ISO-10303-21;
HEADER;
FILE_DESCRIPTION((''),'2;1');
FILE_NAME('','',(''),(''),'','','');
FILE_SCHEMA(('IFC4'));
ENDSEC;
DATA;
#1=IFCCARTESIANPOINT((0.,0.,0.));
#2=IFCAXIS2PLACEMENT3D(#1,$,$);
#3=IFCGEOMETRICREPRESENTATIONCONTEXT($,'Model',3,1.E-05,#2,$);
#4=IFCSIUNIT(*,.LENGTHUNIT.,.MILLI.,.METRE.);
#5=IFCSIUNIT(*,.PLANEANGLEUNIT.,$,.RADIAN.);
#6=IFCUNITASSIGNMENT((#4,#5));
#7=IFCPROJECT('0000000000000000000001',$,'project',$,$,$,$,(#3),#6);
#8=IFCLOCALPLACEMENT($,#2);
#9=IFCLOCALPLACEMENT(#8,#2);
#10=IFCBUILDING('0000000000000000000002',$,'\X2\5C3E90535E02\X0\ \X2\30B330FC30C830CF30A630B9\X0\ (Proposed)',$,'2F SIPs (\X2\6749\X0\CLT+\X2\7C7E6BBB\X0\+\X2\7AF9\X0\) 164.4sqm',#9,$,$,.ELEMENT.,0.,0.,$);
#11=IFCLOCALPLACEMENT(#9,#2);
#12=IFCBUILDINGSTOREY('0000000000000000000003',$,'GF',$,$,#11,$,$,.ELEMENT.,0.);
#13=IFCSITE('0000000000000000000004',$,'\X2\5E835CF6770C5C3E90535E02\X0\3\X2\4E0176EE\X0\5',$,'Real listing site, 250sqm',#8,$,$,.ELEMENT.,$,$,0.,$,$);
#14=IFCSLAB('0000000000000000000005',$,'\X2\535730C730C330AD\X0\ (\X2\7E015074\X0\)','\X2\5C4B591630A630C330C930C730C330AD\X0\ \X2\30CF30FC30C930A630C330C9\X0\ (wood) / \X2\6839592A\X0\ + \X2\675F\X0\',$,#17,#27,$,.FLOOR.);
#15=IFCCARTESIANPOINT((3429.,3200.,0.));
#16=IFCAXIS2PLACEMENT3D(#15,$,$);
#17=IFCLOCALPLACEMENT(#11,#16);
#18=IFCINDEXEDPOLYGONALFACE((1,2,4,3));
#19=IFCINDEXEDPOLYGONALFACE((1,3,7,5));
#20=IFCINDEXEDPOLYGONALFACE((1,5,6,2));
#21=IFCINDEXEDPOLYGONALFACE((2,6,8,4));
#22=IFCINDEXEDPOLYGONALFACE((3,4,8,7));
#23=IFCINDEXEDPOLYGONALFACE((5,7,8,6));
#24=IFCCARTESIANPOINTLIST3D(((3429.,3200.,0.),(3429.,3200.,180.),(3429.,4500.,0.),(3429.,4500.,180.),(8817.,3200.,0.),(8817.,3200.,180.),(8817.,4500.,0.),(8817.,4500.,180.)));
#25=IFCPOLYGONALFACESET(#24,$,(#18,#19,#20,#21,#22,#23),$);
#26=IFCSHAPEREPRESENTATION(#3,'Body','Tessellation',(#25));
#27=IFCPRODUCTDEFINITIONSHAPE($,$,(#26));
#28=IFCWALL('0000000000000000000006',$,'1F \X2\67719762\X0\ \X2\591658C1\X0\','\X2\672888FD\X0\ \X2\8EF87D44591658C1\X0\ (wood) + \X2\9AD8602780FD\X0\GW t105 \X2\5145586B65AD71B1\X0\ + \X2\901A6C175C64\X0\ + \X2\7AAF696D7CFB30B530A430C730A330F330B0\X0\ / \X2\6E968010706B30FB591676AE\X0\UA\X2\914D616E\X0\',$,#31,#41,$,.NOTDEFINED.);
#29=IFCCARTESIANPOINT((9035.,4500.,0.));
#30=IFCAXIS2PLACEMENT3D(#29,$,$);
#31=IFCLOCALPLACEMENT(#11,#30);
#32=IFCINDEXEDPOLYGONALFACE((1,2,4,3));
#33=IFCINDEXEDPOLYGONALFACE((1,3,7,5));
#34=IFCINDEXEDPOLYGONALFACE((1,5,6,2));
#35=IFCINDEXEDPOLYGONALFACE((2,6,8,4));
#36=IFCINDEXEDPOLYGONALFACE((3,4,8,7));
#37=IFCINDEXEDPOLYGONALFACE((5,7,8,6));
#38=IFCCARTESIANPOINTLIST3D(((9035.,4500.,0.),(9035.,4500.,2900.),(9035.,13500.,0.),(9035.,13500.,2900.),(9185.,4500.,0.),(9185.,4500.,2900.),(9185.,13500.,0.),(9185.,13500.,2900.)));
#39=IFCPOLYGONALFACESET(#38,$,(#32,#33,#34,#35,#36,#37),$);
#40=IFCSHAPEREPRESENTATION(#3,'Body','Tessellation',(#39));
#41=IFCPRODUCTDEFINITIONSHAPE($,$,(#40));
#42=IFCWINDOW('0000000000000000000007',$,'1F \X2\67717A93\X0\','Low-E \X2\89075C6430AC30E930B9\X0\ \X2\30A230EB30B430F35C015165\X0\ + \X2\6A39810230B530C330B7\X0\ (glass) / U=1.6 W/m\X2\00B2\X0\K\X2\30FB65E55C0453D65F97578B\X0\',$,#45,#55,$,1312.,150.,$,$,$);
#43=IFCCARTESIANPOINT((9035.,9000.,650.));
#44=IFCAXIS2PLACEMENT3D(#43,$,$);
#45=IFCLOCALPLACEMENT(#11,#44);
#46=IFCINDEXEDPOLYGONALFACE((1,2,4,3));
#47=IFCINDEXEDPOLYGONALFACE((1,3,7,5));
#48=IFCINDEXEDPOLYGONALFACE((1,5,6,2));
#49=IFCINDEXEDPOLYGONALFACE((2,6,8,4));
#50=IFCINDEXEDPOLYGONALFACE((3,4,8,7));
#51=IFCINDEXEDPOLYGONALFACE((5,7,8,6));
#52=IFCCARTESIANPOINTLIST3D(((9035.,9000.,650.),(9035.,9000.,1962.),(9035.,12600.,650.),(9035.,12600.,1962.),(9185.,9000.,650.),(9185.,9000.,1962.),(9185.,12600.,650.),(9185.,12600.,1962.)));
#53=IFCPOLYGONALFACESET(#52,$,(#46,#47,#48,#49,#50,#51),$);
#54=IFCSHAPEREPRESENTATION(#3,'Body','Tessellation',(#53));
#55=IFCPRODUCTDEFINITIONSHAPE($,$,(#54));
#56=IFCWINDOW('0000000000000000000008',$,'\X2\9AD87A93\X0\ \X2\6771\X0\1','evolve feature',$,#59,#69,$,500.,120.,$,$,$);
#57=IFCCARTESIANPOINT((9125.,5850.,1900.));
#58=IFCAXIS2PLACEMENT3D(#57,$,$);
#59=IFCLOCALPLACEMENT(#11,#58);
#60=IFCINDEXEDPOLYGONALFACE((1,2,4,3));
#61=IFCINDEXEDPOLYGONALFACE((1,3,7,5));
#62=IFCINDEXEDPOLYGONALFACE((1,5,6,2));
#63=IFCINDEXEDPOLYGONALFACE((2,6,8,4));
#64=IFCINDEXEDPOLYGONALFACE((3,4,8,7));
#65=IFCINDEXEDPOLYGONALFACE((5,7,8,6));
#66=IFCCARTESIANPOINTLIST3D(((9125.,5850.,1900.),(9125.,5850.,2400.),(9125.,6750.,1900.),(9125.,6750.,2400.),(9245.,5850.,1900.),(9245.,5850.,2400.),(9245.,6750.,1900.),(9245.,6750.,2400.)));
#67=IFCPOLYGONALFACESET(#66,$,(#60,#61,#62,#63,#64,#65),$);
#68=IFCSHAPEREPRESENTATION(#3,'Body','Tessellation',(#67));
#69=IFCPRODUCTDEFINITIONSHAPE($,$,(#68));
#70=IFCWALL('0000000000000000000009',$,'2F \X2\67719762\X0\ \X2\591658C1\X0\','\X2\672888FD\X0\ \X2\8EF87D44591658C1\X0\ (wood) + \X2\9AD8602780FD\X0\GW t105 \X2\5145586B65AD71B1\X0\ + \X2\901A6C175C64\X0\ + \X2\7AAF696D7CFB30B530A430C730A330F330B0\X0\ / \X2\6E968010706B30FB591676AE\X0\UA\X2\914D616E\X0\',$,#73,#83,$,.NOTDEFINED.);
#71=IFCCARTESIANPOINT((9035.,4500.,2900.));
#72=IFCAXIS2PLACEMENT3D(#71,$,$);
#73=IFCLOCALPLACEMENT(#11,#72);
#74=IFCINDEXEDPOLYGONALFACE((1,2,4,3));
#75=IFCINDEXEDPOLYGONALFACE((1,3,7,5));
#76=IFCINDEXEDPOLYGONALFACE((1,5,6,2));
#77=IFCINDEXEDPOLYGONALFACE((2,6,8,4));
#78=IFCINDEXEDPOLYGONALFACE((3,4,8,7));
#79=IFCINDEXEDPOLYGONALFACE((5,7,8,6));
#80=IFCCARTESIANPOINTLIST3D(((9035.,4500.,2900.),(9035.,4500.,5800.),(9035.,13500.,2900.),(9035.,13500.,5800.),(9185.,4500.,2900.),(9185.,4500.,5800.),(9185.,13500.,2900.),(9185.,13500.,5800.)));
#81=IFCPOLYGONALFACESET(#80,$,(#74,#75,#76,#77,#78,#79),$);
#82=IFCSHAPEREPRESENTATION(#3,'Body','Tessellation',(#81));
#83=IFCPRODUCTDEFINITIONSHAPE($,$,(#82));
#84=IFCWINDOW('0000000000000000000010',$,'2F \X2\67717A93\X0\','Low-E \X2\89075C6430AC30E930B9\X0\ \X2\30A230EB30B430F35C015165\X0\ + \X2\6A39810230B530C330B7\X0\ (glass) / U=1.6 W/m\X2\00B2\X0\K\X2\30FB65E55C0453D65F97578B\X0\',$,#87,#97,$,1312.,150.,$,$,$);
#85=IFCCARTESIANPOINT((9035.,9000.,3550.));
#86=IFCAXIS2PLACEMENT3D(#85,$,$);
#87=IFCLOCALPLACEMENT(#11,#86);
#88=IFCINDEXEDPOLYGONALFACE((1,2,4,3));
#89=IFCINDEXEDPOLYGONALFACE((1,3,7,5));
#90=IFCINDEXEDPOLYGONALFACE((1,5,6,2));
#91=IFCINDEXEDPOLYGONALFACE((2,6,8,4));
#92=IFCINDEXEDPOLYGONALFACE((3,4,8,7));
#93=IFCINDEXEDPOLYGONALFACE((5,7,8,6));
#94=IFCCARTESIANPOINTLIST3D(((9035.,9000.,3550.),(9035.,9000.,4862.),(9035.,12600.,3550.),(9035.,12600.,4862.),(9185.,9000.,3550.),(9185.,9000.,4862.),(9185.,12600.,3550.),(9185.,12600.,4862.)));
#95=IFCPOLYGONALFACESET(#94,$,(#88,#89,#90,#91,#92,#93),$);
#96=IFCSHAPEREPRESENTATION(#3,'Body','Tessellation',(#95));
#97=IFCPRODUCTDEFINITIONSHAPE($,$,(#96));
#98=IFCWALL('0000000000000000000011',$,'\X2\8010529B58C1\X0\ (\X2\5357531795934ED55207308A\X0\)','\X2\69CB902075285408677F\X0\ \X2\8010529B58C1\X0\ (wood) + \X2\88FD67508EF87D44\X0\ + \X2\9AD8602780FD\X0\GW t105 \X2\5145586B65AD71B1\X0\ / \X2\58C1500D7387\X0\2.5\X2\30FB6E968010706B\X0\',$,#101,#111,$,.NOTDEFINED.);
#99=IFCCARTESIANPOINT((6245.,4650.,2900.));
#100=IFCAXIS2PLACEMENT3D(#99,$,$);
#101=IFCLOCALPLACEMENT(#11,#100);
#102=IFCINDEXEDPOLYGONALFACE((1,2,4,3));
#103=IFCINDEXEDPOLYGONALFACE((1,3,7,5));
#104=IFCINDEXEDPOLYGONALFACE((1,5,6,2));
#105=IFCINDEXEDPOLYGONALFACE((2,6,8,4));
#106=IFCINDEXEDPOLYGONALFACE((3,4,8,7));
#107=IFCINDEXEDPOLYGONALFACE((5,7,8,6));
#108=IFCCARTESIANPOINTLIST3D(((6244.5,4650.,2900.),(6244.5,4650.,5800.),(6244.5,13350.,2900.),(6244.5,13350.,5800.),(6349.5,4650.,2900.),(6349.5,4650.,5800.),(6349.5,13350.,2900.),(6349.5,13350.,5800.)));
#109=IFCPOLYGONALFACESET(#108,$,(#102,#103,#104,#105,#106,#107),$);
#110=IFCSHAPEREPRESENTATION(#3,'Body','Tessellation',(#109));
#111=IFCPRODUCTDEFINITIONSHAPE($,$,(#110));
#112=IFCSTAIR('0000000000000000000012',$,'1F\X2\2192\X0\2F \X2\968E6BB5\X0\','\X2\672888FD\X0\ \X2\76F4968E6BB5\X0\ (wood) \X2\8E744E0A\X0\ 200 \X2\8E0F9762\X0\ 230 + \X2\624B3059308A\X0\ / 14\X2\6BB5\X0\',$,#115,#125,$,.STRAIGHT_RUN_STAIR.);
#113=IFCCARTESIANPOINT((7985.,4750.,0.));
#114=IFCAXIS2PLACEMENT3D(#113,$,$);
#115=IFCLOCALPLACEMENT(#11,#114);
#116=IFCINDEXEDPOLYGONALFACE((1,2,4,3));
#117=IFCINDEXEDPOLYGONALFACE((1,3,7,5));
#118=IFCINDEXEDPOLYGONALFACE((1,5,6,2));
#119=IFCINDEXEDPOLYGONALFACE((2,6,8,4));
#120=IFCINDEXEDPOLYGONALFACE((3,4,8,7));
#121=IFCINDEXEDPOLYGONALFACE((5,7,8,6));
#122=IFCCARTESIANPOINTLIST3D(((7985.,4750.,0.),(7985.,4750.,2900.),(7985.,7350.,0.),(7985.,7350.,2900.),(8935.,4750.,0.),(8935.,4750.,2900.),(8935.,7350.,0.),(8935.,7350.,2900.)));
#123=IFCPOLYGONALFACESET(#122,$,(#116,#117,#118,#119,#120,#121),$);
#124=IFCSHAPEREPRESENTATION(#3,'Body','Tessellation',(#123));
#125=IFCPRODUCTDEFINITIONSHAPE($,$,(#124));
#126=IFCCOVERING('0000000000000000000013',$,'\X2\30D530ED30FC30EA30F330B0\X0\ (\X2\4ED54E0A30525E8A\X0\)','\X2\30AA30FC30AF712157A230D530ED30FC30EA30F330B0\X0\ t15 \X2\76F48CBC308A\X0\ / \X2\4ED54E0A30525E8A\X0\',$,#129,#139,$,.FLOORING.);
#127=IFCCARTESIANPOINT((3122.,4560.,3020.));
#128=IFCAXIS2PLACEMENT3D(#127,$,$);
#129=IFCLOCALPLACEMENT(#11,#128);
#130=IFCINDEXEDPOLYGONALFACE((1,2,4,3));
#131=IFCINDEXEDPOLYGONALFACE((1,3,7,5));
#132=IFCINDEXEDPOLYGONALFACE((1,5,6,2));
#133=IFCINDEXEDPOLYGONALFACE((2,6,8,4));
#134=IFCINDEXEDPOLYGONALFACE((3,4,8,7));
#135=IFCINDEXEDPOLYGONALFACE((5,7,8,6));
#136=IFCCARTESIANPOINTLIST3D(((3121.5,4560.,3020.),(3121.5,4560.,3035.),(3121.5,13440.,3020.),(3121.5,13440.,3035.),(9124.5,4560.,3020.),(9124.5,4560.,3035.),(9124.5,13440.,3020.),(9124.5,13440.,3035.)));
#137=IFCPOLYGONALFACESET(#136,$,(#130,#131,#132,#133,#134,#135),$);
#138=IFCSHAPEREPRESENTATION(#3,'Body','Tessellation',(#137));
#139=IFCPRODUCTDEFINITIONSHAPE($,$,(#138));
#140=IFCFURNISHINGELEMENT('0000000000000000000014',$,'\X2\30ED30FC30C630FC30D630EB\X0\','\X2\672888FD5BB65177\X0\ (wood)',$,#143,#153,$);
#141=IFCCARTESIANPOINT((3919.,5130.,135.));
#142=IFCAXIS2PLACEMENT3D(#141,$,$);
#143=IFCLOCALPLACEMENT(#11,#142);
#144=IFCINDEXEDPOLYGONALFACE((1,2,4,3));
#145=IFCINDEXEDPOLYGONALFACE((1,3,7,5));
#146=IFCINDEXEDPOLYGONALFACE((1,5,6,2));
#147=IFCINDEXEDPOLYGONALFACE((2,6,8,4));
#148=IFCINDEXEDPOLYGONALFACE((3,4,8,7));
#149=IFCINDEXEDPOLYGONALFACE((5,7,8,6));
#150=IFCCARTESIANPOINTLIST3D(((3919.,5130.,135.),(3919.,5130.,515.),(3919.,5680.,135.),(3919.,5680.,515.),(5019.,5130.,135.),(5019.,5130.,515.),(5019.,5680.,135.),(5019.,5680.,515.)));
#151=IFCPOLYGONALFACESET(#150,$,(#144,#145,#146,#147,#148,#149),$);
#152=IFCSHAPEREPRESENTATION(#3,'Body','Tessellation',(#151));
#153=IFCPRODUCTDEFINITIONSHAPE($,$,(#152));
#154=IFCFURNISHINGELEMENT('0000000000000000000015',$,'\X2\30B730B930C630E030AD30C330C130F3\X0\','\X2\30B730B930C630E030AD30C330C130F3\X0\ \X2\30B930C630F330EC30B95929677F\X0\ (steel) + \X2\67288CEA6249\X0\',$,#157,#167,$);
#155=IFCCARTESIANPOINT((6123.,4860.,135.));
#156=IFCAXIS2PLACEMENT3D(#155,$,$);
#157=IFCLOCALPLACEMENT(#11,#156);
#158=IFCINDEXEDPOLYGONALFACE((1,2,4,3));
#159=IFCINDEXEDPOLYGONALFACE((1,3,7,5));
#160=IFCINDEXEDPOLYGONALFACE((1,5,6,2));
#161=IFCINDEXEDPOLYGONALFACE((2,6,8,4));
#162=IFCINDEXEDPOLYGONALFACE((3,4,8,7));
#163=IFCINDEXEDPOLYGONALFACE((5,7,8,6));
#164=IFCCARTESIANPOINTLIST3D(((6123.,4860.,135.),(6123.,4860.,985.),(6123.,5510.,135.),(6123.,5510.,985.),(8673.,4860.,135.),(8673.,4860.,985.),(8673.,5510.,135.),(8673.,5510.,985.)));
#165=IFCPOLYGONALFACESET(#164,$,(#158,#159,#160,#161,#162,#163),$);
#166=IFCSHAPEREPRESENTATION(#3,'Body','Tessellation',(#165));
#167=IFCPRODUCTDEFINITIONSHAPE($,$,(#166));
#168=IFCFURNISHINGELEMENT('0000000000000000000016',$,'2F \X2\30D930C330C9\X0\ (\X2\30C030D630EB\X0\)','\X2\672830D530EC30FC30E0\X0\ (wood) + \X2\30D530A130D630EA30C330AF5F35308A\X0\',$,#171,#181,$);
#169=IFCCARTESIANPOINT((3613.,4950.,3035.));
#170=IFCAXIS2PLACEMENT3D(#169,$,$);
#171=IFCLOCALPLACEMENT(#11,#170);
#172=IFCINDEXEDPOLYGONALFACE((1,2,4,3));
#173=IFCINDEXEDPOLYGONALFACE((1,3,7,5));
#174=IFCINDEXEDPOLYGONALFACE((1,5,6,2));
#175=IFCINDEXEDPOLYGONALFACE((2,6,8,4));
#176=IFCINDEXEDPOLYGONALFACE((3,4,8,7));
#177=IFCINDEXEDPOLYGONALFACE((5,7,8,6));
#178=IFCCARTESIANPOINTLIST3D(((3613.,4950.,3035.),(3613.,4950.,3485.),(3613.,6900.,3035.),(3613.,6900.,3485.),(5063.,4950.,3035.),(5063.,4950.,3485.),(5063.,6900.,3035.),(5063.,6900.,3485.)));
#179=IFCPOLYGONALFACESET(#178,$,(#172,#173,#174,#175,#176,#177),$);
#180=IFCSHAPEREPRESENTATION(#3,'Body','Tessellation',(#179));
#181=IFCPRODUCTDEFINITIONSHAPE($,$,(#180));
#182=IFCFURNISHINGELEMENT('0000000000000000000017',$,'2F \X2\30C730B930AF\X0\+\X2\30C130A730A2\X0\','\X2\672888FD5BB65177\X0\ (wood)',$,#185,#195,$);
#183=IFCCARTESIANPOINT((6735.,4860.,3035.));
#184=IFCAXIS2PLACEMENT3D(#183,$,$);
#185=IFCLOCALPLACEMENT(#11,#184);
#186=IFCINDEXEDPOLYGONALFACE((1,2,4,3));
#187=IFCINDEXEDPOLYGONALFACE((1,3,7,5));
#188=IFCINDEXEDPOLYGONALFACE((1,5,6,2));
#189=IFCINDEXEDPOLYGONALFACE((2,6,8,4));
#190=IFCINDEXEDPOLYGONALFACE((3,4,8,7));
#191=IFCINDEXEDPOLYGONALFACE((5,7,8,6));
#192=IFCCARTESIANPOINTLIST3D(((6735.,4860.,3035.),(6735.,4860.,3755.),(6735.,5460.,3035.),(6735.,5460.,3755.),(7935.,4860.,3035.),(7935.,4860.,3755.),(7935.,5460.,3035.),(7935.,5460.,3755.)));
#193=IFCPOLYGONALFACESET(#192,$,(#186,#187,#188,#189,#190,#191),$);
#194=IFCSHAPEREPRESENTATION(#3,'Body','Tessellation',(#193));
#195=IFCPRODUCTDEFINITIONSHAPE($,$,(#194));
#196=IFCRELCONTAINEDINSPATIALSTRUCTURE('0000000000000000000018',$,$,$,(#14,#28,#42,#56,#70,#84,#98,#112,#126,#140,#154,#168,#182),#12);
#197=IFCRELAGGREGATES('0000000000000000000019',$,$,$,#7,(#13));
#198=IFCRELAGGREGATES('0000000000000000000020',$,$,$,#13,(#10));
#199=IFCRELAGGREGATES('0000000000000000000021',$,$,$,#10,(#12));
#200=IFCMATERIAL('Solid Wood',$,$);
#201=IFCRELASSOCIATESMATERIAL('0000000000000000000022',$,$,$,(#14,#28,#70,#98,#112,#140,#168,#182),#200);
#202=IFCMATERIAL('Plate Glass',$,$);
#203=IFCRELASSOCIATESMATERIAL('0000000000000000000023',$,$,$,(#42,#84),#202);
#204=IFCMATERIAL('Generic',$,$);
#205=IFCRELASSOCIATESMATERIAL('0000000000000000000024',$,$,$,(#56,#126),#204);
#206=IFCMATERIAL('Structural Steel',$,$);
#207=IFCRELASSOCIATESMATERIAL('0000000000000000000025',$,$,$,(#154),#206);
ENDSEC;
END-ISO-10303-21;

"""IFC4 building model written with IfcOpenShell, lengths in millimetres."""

from ifc_helpers import new_model, si_unit, frame, frame_2d, origin, place, context, project, spatial, rectangle, extrude, material, element, fill, save


model = new_model("IFC4")

# Units and contexts
model_context = context("Model", 3, precision=1e-05, world=origin())
ifc_project = project(units=[si_unit("LENGTHUNIT", "METRE", prefix="MILLI"), si_unit("PLANEANGLEUNIT", "RADIAN")], contexts=[model_context])

# Site, building, storey
site_placement = place(None, origin())
site = spatial("IfcSite", under=ifc_project, at=site_placement, Name="広島県尾道市3丁目5", ObjectType="Real listing site, 250sqm", CompositionType="ELEMENT", RefElevation=0.0)
building_placement = place(site_placement, origin())
building = spatial("IfcBuilding", under=site, at=building_placement, Name="尾道市 コートハウス (Proposed)", ObjectType="2F SIPs (杉CLT+籾殻+竹) 164.4sqm", CompositionType="ELEMENT", ElevationOfRefHeight=0.0, ElevationOfTerrain=0.0)
storey_placement = place(building_placement, origin())
storey = spatial("IfcBuildingStorey", under=building, at=storey_placement, Name="GF", CompositionType="ELEMENT", Elevation=0.0)

# Slab
ifc_material_1 = material(Name="Solid Wood")
slab_placement = place(storey_placement, frame((3429.0, 3200.0, 0.0)))
element("IfcSlab", 1, at=slab_placement, inside=storey, material=ifc_material_1, Name="南デッキ (縁側)", Description="屋外ウッドデッキ ハードウッド (wood) / 根太 + 束", PredefinedType="FLOOR", context=model_context, shape_type="SweptSolid", body=[
    extrude(rectangle(XDim=5388.0, YDim=1300.0, at=frame_2d((2694.0, 650.0))), frame((3429.0, 3200.0, 0.0)), (0.0, 0.0, 1.0), 180.0),
])

# Wall, openings, windows
wall_1_placement = place(storey_placement, frame((9035.0, 4500.0, 0.0)))
wall_1 = element("IfcWall", 2, at=wall_1_placement, inside=storey, material=ifc_material_1, Name="1F 東面 外壁", Description="木製 軸組外壁 (wood) + 高性能GW t105 充填断熱 + 通気層 + 窯業系サイディング / 準耐火・外皮UA配慮", PredefinedType="NOTDEFINED", context=model_context, shape_type="SweptSolid", body=[
    extrude(rectangle(XDim=150.0, YDim=9000.0, at=frame_2d((75.0, 4500.0))), frame((9035.0, 4500.0, 0.0)), (0.0, 0.0, 1.0), 2900.0),
])
opening_1_placement = place(storey_placement, frame((9035.0, 9000.0, 650.0)))
opening_1 = element("IfcOpeningElement", 3, at=opening_1_placement, cuts=wall_1, PredefinedType="NOTDEFINED", context=model_context, shape_type="SweptSolid", body=[
    extrude(rectangle(XDim=150.0, YDim=3600.0, at=frame_2d((75.0, 1800.0))), frame((9035.0, 9000.0, 650.0)), (0.0, 0.0, 1.0), 1312.0),
])
opening_2_placement = place(storey_placement, frame((9125.0, 5850.0, 1900.0)))
opening_2 = element("IfcOpeningElement", 4, at=opening_2_placement, cuts=wall_1, PredefinedType="NOTDEFINED", context=model_context, shape_type="SweptSolid", body=[
    extrude(rectangle(XDim=120.0, YDim=900.0, at=frame_2d((60.0, 450.0))), frame((9125.0, 5850.0, 1900.0)), (0.0, 0.0, 1.0), 500.0),
])
ifc_material_2 = material(Name="Plate Glass")
window_1_placement = place(storey_placement, frame((9035.0, 9000.0, 650.0)))
window_1 = element("IfcWindow", 5, at=window_1_placement, inside=storey, material=ifc_material_2, Name="1F 東窓", Description="Low-E 複層ガラス アルゴン封入 + 樹脂サッシ (glass) / U=1.6 W/m²K・日射取得型", OverallHeight=1312.0, OverallWidth=150.0, context=model_context, shape_type="SweptSolid", body=[
    extrude(rectangle(XDim=150.0, YDim=3600.0, at=frame_2d((75.0, 1800.0))), frame((9035.0, 9000.0, 650.0)), (0.0, 0.0, 1.0), 1312.0),
])
fill(opening_1, window_1)
ifc_material_3 = material(Name="Generic")
window_2_placement = place(storey_placement, frame((9125.0, 5850.0, 1900.0)))
window_2 = element("IfcWindow", 6, at=window_2_placement, inside=storey, material=ifc_material_3, Name="高窓 東1", Description="evolve feature", OverallHeight=500.0, OverallWidth=120.0, context=model_context, shape_type="SweptSolid", body=[
    extrude(rectangle(XDim=120.0, YDim=900.0, at=frame_2d((60.0, 450.0))), frame((9125.0, 5850.0, 1900.0)), (0.0, 0.0, 1.0), 500.0),
])
fill(opening_2, window_2)

# Wall, opening, window
wall_2_placement = place(storey_placement, frame((9035.0, 4500.0, 2900.0)))
wall_2 = element("IfcWall", 7, at=wall_2_placement, inside=storey, material=ifc_material_1, Name="2F 東面 外壁", Description="木製 軸組外壁 (wood) + 高性能GW t105 充填断熱 + 通気層 + 窯業系サイディング / 準耐火・外皮UA配慮", PredefinedType="NOTDEFINED", context=model_context, shape_type="SweptSolid", body=[
    extrude(rectangle(XDim=150.0, YDim=9000.0, at=frame_2d((75.0, 4500.0))), frame((9035.0, 4500.0, 2900.0)), (0.0, 0.0, 1.0), 2900.0),
])
opening_3_placement = place(storey_placement, frame((9035.0, 9000.0, 3550.0)))
opening_3 = element("IfcOpeningElement", 8, at=opening_3_placement, cuts=wall_2, PredefinedType="NOTDEFINED", context=model_context, shape_type="SweptSolid", body=[
    extrude(rectangle(XDim=150.0, YDim=3600.0, at=frame_2d((75.0, 1800.0))), frame((9035.0, 9000.0, 3550.0)), (0.0, 0.0, 1.0), 1312.0),
])
window_3_placement = place(storey_placement, frame((9035.0, 9000.0, 3550.0)))
window_3 = element("IfcWindow", 9, at=window_3_placement, inside=storey, material=ifc_material_2, Name="2F 東窓", Description="Low-E 複層ガラス アルゴン封入 + 樹脂サッシ (glass) / U=1.6 W/m²K・日射取得型", OverallHeight=1312.0, OverallWidth=150.0, context=model_context, shape_type="SweptSolid", body=[
    extrude(rectangle(XDim=150.0, YDim=3600.0, at=frame_2d((75.0, 1800.0))), frame((9035.0, 9000.0, 3550.0)), (0.0, 0.0, 1.0), 1312.0),
])
fill(opening_3, window_3)

# Wall
wall_3_placement = place(storey_placement, frame((6245.0, 4650.0, 2900.0)))
element("IfcWall", 10, at=wall_3_placement, inside=storey, material=ifc_material_1, Name="耐力壁 (南北間仕切り)", Description="構造用合板 耐力壁 (wood) + 製材軸組 + 高性能GW t105 充填断熱 / 壁倍率2.5・準耐火", PredefinedType="NOTDEFINED", context=model_context, shape_type="SweptSolid", body=[
    extrude(rectangle(XDim=105.0, YDim=8700.0, at=frame_2d((52.0, 4350.0))), frame((6245.0, 4650.0, 2900.0)), (0.0, 0.0, 1.0), 2900.0),
])

# Stair
stair_placement = place(storey_placement, frame((7985.0, 4750.0, 0.0)))
element("IfcStair", 11, at=stair_placement, inside=storey, material=ifc_material_1, Name="1F→2F 階段", Description="木製 直階段 (wood) 蹴上 200 踏面 230 + 手すり / 14段", PredefinedType="STRAIGHT_RUN_STAIR", context=model_context, shape_type="SweptSolid", body=[
    extrude(rectangle(XDim=950.0, YDim=2600.0, at=frame_2d((475.0, 1300.0))), frame((7985.0, 4750.0, 0.0)), (0.0, 0.0, 1.0), 2900.0),
])

# Covering
covering_placement = place(storey_placement, frame((3122.0, 4560.0, 3020.0)))
element("IfcCovering", 12, at=covering_placement, inside=storey, material=ifc_material_3, Name="フローリング (仕上げ床)", Description="オーク無垢フローリング t15 直貼り / 仕上げ床", PredefinedType="FLOORING", context=model_context, shape_type="SweptSolid", body=[
    extrude(rectangle(XDim=6003.0, YDim=8880.0, at=frame_2d((3001.0, 4440.0))), frame((3122.0, 4560.0, 3020.0)), (0.0, 0.0, 1.0), 15.0),
])

# Furnishing elements
furnishing_1_placement = place(storey_placement, frame((3919.0, 5130.0, 135.0)))
element("IfcFurnishingElement", 13, at=furnishing_1_placement, inside=storey, material=ifc_material_1, Name="ローテーブル", Description="木製家具 (wood)", context=model_context, shape_type="SweptSolid", body=[
    extrude(rectangle(XDim=1100.0, YDim=550.0, at=frame_2d((550.0, 275.0))), frame((3919.0, 5130.0, 135.0)), (0.0, 0.0, 1.0), 380.0),
])
ifc_material_4 = material(Name="Structural Steel")
furnishing_2_placement = place(storey_placement, frame((6123.0, 4860.0, 135.0)))
element("IfcFurnishingElement", 14, at=furnishing_2_placement, inside=storey, material=ifc_material_4, Name="システムキッチン", Description="システムキッチン ステンレス天板 (steel) + 木質扉", context=model_context, shape_type="SweptSolid", body=[
    extrude(rectangle(XDim=2550.0, YDim=650.0, at=frame_2d((1275.0, 325.0))), frame((6123.0, 4860.0, 135.0)), (0.0, 0.0, 1.0), 850.0),
])
furnishing_3_placement = place(storey_placement, frame((3613.0, 4950.0, 3035.0)))
element("IfcFurnishingElement", 15, at=furnishing_3_placement, inside=storey, material=ifc_material_1, Name="2F ベッド (ダブル)", Description="木フレーム (wood) + ファブリック張り", context=model_context, shape_type="SweptSolid", body=[
    extrude(rectangle(XDim=1450.0, YDim=1950.0, at=frame_2d((725.0, 975.0))), frame((3613.0, 4950.0, 3035.0)), (0.0, 0.0, 1.0), 450.0),
])
furnishing_4_placement = place(storey_placement, frame((6735.0, 4860.0, 3035.0)))
element("IfcFurnishingElement", 16, at=furnishing_4_placement, inside=storey, material=ifc_material_1, Name="2F デスク+チェア", Description="木製家具 (wood)", context=model_context, shape_type="SweptSolid", body=[
    extrude(rectangle(XDim=1200.0, YDim=600.0, at=frame_2d((600.0, 300.0))), frame((6735.0, 4860.0, 3035.0)), (0.0, 0.0, 1.0), 720.0),
])

save(model, "model.ifc")
